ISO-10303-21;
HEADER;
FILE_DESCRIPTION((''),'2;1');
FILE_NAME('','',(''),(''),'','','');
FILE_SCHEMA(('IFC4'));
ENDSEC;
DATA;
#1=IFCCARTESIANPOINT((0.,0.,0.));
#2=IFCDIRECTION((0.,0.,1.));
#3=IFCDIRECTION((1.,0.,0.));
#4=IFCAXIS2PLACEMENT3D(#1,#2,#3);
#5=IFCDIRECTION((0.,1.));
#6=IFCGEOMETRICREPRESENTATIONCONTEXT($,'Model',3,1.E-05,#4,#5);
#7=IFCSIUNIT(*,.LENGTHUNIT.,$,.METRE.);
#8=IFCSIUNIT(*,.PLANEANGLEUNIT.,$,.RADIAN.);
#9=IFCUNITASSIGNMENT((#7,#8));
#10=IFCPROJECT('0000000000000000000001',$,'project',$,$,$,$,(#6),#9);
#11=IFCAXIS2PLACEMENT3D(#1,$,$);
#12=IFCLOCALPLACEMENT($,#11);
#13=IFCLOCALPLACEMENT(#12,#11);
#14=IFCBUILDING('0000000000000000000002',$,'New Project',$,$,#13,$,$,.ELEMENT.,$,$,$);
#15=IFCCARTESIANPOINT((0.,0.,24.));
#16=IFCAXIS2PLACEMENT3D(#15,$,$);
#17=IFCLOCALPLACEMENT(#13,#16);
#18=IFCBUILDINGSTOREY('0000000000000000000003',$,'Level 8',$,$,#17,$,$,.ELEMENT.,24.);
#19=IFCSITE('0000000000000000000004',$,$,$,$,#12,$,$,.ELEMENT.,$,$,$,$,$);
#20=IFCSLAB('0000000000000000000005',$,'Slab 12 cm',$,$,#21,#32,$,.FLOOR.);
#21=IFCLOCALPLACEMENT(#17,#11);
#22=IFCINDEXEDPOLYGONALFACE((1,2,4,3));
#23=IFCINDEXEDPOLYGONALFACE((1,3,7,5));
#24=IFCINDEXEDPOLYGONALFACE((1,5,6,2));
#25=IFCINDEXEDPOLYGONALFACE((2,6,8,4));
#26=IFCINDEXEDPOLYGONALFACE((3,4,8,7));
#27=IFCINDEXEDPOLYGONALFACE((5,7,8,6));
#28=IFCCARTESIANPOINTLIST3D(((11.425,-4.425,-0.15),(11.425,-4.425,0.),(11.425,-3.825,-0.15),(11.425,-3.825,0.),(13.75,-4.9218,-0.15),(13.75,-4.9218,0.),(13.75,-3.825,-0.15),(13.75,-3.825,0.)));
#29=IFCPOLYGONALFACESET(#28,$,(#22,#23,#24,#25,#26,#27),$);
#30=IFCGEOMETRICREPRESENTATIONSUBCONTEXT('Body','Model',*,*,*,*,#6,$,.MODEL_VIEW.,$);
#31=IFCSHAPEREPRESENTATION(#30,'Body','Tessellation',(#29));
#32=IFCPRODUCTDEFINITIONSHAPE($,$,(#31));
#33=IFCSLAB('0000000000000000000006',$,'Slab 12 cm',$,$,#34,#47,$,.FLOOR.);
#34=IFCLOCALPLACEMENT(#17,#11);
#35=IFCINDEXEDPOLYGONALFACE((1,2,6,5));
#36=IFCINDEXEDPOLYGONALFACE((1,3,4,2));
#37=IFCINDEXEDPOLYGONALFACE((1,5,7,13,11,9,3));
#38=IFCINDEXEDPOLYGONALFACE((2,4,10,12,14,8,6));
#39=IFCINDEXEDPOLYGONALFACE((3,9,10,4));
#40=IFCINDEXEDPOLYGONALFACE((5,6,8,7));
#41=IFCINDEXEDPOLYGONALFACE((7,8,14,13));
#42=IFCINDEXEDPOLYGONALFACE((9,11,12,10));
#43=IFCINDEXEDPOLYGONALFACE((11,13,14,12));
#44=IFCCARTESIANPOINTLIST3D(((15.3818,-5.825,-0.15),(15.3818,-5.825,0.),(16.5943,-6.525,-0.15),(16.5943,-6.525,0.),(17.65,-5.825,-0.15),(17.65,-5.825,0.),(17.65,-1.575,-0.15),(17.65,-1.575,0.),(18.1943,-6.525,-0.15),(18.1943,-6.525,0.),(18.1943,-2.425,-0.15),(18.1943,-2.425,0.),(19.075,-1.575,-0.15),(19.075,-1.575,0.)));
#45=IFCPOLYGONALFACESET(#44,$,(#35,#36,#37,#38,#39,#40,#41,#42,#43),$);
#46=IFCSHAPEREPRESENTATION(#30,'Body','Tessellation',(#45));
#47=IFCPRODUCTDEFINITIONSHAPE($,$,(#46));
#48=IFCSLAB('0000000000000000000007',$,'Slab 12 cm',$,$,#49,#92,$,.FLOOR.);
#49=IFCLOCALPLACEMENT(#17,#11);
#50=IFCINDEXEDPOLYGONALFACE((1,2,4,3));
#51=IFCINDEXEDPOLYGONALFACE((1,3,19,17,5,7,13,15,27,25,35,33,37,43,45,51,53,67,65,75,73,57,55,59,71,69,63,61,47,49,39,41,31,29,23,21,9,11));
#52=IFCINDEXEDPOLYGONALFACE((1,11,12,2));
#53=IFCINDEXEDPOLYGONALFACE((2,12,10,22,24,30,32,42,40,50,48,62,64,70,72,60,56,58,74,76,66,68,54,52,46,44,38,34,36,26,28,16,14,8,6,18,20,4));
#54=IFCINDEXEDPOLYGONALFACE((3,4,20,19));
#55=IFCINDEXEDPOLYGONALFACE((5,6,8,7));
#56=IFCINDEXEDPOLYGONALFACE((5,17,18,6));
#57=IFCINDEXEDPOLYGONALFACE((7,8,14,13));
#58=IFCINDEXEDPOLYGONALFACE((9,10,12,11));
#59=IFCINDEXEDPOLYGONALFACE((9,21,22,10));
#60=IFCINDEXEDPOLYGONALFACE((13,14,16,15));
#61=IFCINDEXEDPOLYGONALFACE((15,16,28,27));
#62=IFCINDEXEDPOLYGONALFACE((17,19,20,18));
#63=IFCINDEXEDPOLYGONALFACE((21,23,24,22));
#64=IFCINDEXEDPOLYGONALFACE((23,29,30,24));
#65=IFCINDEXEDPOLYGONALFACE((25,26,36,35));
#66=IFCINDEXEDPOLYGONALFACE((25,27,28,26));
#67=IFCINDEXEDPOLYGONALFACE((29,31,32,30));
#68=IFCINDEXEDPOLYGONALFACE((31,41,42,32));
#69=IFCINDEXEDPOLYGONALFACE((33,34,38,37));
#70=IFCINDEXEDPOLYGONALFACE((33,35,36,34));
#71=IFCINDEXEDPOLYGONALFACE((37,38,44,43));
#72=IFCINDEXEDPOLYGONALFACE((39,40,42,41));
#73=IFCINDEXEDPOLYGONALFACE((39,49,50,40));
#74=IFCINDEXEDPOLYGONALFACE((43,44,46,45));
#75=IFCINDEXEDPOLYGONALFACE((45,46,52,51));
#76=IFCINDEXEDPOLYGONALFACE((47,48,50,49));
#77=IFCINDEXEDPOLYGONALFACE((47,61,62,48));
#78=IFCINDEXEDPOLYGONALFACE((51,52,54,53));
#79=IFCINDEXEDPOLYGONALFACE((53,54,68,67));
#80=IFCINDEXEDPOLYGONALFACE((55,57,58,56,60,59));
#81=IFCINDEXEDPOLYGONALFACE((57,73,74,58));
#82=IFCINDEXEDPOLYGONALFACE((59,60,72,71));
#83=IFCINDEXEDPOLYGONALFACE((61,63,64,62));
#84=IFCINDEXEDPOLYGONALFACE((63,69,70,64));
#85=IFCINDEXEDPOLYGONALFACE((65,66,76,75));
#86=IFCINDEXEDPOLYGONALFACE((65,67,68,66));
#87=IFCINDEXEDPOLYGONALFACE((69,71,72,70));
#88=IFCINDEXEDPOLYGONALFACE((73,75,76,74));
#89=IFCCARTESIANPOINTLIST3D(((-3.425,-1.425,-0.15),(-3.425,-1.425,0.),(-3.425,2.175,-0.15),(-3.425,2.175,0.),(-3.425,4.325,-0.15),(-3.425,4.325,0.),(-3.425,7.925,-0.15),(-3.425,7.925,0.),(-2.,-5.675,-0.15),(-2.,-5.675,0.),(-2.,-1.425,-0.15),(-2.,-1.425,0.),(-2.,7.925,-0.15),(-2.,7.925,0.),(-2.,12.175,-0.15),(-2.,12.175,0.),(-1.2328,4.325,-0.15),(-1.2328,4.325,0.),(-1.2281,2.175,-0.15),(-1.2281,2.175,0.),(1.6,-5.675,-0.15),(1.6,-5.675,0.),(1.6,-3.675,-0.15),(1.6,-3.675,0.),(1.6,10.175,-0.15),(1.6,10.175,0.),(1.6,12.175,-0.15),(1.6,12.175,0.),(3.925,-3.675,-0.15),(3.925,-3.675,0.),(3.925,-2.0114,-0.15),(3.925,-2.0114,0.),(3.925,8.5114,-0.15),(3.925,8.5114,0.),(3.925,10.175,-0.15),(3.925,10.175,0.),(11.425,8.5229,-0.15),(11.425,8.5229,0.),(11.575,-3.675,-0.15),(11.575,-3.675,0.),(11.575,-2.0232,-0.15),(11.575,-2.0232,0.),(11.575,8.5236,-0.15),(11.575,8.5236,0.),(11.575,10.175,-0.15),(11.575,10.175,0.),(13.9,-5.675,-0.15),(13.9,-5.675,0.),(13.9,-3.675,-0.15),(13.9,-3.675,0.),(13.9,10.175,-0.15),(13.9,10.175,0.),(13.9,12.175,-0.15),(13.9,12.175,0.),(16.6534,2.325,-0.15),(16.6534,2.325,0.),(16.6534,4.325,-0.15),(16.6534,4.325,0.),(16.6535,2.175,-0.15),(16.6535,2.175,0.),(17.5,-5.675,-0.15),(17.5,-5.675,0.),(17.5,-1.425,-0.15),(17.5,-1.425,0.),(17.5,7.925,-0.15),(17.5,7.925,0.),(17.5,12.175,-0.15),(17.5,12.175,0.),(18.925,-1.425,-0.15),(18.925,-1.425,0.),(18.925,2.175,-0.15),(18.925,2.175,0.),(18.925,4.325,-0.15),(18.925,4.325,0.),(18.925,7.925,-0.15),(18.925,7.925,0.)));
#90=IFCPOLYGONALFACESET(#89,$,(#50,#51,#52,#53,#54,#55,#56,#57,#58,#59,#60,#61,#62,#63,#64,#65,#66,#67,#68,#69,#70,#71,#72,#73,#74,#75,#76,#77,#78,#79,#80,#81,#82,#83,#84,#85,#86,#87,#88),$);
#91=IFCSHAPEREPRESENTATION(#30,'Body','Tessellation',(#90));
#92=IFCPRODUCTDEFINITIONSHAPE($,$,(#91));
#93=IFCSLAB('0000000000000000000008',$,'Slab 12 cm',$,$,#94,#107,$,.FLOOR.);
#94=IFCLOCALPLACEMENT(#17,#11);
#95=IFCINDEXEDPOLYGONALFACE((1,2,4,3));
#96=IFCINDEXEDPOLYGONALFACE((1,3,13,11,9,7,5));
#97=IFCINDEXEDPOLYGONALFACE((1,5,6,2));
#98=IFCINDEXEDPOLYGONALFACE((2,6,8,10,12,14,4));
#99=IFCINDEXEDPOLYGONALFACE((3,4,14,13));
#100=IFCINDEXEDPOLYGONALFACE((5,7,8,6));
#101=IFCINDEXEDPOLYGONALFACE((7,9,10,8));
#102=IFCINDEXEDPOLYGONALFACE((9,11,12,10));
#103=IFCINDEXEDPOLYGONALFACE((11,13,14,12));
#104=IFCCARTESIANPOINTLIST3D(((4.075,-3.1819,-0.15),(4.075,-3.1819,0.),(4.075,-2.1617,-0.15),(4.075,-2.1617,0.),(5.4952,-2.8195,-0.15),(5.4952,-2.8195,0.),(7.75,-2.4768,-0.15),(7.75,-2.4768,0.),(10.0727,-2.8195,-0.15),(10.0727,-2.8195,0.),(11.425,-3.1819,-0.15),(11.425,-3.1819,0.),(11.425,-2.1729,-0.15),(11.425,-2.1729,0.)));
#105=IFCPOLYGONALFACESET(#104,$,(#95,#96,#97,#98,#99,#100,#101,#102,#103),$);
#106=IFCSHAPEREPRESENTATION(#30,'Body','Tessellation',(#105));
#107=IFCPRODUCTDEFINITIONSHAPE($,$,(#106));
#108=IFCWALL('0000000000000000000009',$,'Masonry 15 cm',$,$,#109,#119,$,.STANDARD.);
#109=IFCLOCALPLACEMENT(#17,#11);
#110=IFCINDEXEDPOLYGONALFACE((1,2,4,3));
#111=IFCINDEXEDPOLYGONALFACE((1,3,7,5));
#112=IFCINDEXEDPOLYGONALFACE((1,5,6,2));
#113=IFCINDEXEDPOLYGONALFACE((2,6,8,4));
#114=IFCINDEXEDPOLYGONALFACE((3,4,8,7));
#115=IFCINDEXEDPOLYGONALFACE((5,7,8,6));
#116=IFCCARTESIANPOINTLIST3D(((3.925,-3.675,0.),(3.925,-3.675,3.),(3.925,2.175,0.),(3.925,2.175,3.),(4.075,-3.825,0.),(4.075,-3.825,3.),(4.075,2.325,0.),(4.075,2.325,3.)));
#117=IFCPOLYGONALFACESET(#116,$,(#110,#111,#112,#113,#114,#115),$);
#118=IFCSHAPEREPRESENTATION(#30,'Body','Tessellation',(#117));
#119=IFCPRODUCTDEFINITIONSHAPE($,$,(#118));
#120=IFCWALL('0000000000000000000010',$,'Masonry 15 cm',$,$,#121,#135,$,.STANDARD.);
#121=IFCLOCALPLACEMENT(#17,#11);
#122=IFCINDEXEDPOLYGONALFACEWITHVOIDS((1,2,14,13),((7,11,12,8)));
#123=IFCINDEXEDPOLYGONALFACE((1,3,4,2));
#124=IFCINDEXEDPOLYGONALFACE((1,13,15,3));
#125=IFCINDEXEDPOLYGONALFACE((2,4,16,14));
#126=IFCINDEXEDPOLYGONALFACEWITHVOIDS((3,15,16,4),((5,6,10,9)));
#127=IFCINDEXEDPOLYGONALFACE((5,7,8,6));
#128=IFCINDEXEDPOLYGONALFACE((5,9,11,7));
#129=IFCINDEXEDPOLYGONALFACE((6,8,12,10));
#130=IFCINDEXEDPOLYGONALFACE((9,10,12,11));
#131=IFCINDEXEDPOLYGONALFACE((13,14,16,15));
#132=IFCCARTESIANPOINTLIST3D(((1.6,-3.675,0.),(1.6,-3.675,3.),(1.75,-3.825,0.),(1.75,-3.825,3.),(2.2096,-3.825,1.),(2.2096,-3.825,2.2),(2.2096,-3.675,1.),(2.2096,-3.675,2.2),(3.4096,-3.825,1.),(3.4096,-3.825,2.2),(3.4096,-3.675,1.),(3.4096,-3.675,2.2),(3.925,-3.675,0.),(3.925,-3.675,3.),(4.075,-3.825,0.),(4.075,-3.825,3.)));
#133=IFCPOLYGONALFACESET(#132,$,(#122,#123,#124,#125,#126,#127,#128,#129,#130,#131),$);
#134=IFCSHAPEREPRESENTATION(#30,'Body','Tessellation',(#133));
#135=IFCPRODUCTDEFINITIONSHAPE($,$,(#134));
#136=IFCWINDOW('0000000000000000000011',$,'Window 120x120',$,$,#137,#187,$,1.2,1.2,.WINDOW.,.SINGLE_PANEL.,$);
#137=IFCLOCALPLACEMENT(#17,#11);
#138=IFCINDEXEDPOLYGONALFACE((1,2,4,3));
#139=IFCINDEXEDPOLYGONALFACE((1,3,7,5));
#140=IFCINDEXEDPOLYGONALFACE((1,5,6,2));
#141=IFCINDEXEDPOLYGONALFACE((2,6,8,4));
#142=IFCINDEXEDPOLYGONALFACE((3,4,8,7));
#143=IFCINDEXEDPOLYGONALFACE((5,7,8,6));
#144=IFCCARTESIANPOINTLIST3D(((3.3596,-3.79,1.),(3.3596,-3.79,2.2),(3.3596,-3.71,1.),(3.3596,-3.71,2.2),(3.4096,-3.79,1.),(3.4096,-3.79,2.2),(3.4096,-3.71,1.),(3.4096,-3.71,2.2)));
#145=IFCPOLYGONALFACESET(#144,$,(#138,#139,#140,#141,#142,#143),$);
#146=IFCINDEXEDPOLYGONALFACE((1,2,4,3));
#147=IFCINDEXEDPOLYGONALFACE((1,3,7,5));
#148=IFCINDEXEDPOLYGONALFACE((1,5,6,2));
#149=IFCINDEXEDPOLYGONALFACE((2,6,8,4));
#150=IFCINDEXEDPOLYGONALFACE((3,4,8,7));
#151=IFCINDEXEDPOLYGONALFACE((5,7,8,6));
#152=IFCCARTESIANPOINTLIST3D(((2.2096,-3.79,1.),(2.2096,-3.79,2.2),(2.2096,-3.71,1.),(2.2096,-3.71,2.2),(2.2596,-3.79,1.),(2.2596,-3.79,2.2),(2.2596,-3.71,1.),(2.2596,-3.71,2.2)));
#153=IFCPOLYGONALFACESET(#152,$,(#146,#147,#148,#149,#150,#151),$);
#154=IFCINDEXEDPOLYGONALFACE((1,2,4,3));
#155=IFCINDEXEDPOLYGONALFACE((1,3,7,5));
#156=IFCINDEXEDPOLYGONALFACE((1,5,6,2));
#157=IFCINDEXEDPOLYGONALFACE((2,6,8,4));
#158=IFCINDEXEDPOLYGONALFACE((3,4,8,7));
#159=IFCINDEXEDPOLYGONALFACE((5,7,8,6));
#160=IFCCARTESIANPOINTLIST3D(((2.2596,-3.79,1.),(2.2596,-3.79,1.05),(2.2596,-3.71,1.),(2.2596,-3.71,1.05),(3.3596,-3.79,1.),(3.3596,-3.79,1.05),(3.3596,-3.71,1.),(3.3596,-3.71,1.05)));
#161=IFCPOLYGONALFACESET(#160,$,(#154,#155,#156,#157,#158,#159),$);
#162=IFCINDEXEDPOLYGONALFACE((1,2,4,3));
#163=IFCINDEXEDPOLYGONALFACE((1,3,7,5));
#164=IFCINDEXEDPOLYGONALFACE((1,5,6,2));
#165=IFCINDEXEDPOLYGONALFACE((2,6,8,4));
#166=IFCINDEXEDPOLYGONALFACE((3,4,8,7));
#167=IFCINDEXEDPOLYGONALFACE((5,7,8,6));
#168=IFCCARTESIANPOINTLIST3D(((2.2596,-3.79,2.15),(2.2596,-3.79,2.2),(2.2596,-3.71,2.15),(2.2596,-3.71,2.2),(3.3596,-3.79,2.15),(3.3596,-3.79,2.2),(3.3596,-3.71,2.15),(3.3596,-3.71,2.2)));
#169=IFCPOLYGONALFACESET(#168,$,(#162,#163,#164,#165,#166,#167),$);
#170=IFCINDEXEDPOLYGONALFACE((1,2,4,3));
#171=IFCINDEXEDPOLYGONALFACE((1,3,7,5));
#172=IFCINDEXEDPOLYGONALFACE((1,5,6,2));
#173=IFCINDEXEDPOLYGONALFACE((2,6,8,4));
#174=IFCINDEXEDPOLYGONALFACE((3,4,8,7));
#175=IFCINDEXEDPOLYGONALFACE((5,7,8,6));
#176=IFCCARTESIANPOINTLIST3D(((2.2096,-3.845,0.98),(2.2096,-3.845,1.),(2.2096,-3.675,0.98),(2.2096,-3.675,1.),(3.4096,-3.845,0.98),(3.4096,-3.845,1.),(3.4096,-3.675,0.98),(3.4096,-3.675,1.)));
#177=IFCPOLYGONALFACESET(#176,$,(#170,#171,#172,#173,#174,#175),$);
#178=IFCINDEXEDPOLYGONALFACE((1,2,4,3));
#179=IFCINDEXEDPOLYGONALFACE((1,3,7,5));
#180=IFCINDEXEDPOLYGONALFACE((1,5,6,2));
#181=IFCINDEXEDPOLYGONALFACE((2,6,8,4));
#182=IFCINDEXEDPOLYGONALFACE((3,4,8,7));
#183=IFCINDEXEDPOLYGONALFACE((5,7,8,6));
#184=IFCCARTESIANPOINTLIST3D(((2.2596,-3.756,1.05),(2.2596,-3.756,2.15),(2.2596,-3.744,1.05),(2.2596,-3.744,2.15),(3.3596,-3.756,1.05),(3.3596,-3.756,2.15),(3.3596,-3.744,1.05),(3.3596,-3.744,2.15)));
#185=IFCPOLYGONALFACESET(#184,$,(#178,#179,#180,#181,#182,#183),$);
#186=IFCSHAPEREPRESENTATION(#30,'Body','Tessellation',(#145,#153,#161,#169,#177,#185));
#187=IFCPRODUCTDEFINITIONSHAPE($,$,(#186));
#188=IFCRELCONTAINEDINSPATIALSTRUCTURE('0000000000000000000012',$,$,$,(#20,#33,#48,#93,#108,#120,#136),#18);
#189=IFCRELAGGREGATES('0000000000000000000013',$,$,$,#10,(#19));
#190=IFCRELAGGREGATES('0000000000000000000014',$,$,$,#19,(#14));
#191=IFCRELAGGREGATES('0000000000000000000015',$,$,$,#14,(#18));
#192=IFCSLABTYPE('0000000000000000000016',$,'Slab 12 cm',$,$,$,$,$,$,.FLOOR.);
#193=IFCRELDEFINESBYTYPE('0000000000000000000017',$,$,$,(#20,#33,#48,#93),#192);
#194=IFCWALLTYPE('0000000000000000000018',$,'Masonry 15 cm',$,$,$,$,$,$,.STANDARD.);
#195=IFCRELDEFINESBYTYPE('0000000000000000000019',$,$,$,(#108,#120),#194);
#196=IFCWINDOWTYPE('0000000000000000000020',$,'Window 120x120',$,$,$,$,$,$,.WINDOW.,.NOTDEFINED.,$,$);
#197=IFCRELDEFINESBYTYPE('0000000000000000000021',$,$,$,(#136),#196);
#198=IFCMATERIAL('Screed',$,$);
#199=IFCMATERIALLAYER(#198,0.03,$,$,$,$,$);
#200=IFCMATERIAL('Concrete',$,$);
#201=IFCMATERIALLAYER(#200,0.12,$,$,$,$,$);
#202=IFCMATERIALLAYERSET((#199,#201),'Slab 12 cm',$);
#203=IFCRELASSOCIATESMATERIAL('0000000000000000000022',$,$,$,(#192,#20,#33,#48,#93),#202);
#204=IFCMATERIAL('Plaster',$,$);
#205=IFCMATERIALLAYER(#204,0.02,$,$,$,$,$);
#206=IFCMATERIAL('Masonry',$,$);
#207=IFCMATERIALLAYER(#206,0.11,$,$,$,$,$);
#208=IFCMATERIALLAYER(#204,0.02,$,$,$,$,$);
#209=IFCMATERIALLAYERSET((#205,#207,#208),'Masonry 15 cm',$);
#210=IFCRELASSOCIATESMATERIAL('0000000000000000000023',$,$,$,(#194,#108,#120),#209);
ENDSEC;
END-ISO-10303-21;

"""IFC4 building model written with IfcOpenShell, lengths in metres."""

from ifc_helpers import new_model, si_unit, direction, frame, frame_2d, origin, origin_with_axes, place, context, subcontext, project, spatial, polyline, rectangle, outline, extrude, material, layer, layer_set, layer_usage, type_object, element, fill, save


model = new_model("IFC4")

# Units and contexts
model_context = context("Model", 3, precision=1e-05, world=origin_with_axes(), true_north=direction((0.0, 1.0)))
body_context = subcontext(model_context, "Body", "Model", "MODEL_VIEW")
ifc_project = project(units=[si_unit("LENGTHUNIT", "METRE"), si_unit("PLANEANGLEUNIT", "RADIAN")], contexts=[model_context])

# Site, building, storey
site_placement = place(None, origin())
site = spatial("IfcSite", under=ifc_project, at=site_placement, CompositionType="ELEMENT")
building_placement = place(site_placement, origin())
building = spatial("IfcBuilding", under=site, at=building_placement, Name="New Project", CompositionType="ELEMENT")
storey_placement = place(building_placement, frame((0.0, 0.0, 24.0)))
storey = spatial("IfcBuildingStorey", under=building, at=storey_placement, Name="Level 8", CompositionType="ELEMENT", Elevation=24.0)

# Slabs
ifc_material_1 = material(Name="Screed")
ifc_layer_1 = layer(ifc_material_1, 0.03)
ifc_material_2 = material(Name="Concrete")
ifc_layer_2 = layer(ifc_material_2, 0.12)
ifc_layer_set_1 = layer_set([ifc_layer_1, ifc_layer_2], Name="Slab 12 cm")
ifc_layer_usage_1 = layer_usage(ifc_layer_set_1, "AXIS3", "NEGATIVE", 0.15)
slab_type = type_object("IfcSlabType", Name="Slab 12 cm", PredefinedType="FLOOR", material=ifc_layer_set_1)
slab_1_placement = place(storey_placement, frame((0.0, 0.0, -0.15)))
element("IfcSlab", 1, at=slab_1_placement, inside=storey, type_object=slab_type, material=ifc_layer_usage_1, Name="Slab 12 cm", PredefinedType="FLOOR", context=body_context, shape_type="SweptSolid", body=[
    extrude(outline(polyline([(11.425, -3.825), (11.425, -4.425), (13.75, -4.9218), (13.75, -3.825), (11.425, -3.825)])), origin(), (0.0, 0.0, 1.0), 0.15),
])
slab_2_placement = place(storey_placement, frame((0.0, 0.0, -0.15)))
element("IfcSlab", 2, at=slab_2_placement, inside=storey, type_object=slab_type, material=ifc_layer_usage_1, Name="Slab 12 cm", PredefinedType="FLOOR", context=body_context, shape_type="SweptSolid", body=[
    extrude(outline(polyline([(15.3818, -5.825), (16.5943, -6.525), (18.1943, -6.525), (18.1943, -2.425), (19.075, -1.575), (17.65, -1.575), (17.65, -5.825), (15.3818, -5.825)])), origin(), (0.0, 0.0, 1.0), 0.15),
])
slab_3_placement = place(storey_placement, frame((0.0, 0.0, -0.15)))
element("IfcSlab", 3, at=slab_3_placement, inside=storey, type_object=slab_type, material=ifc_layer_usage_1, Name="Slab 12 cm", PredefinedType="FLOOR", context=body_context, shape_type="SweptSolid", body=[
    extrude(outline(polyline([(-2.0, 7.925), (-3.425, 7.925), (-3.425, 4.325), (-1.2328, 4.325), (-1.2281, 2.175), (-3.425, 2.175), (-3.425, -1.425), (-2.0, -1.425), (-2.0, -5.675), (1.6, -5.675), (1.6, -3.675), (3.925, -3.675), (3.925, -2.0114), (11.575, -2.0232), (11.575, -3.675), (13.9, -3.675), (13.9, -5.675), (17.5, -5.675), (17.5, -1.425), (18.925, -1.425), (18.925, 2.175), (16.6535, 2.175), (16.6534, 2.325), (16.6534, 4.325), (18.925, 4.325), (18.925, 7.925), (17.5, 7.925), (17.5, 12.175), (13.9, 12.175), (13.9, 10.175), (11.575, 10.175), (11.575, 8.5236), (11.425, 8.5229), (3.925, 8.5114), (3.925, 10.175), (1.6, 10.175), (1.6, 12.175), (-2.0, 12.175), (-2.0, 7.925)])), origin(), (0.0, 0.0, 1.0), 0.15),
])
slab_4_placement = place(storey_placement, frame((0.0, 0.0, -0.15)))
element("IfcSlab", 4, at=slab_4_placement, inside=storey, type_object=slab_type, material=ifc_layer_usage_1, Name="Slab 12 cm", PredefinedType="FLOOR", context=body_context, shape_type="SweptSolid", body=[
    extrude(outline(polyline([(4.075, -3.1819), (5.4952, -2.8195), (7.75, -2.4768), (10.0727, -2.8195), (11.425, -3.1819), (11.425, -2.1729), (4.075, -2.1617), (4.075, -3.1819)])), origin(), (0.0, 0.0, 1.0), 0.15),
])

# Wall
ifc_material_3 = material(Name="Plaster")
ifc_layer_3 = layer(ifc_material_3, 0.02)
ifc_material_4 = material(Name="Masonry")
ifc_layer_4 = layer(ifc_material_4, 0.11)
ifc_layer_5 = layer(ifc_material_3, 0.02)
ifc_layer_set_2 = layer_set([ifc_layer_3, ifc_layer_4, ifc_layer_5], Name="Masonry 15 cm")
ifc_layer_usage_2 = layer_usage(ifc_layer_set_2, "AXIS2", "NEGATIVE", 0.075)
wall_type_1 = type_object("IfcWallType", Name="Masonry 15 cm", PredefinedType="STANDARD", material=ifc_layer_set_2)
wall_1_placement = place(storey_placement, frame((4.0, 2.25, 0.0), z_axis=(0.0, 0.0, 1.0), x_axis=(0.0, -1.0, 0.0)))
element("IfcWall", 5, at=wall_1_placement, inside=storey, type_object=wall_type_1, material=ifc_layer_usage_2, Name="Masonry 15 cm", PredefinedType="STANDARD", context=body_context, shape_type="SweptSolid", body=[
    extrude(outline(polyline([(0.075, -0.075), (5.925, -0.075), (6.075, 0.075), (-0.075, 0.075), (0.075, -0.075)])), origin(), (0.0, 0.0, 1.0), 3.0),
])

# Wall, opening, window
wall_2_placement = place(storey_placement, frame((4.0, -3.75, 0.0), z_axis=(0.0, 0.0, 1.0), x_axis=(-1.0, 0.0, 0.0)))
wall_2 = element("IfcWall", 6, at=wall_2_placement, inside=storey, type_object=wall_type_1, material=ifc_layer_usage_2, Name="Masonry 15 cm", PredefinedType="STANDARD", context=body_context, shape_type="SweptSolid", body=[
    extrude(outline(polyline([(0.075, -0.075), (2.4, -0.075), (2.25, 0.075), (-0.075, 0.075), (0.075, -0.075)])), origin(), (0.0, 0.0, 1.0), 3.0),
])
opening_1_placement = place(wall_2_placement, frame((0.5904, 0.0, 1.0)))
opening_1 = element("IfcOpeningElement", 7, at=opening_1_placement, cuts=wall_2, PredefinedType="OPENING", context=body_context, shape_type="SweptSolid", body=[
    extrude(rectangle(XDim=1.2, YDim=0.25, at=frame_2d((0.6, 0.0))), origin(), (0.0, 0.0, 1.0), 1.2),
])
window_type = type_object("IfcWindowType", Name="Window 120x120", PartitioningType="NOTDEFINED", PredefinedType="WINDOW")
window_1_placement = place(opening_1_placement, origin())
window_1 = element("IfcWindow", 8, at=window_1_placement, inside=storey, type_object=window_type, Name="Window 120x120", OverallHeight=1.2, OverallWidth=1.2, PartitioningType="SINGLE_PANEL", PredefinedType="WINDOW", context=body_context, shape_type="SweptSolid", body=[
    extrude(outline(polyline([(0.0, -0.04), (0.05, -0.04), (0.05, 0.04), (0.0, 0.04), (0.0, -0.04)])), origin(), (0.0, 0.0, 1.0), 1.2),
    extrude(outline(polyline([(1.15, -0.04), (1.2, -0.04), (1.2, 0.04), (1.15, 0.04), (1.15, -0.04)])), origin(), (0.0, 0.0, 1.0), 1.2),
    extrude(outline(polyline([(0.05, -0.04), (1.15, -0.04), (1.15, 0.04), (0.05, 0.04), (0.05, -0.04)])), origin(), (0.0, 0.0, 1.0), 0.05),
    extrude(outline(polyline([(0.05, -0.04), (1.15, -0.04), (1.15, 0.04), (0.05, 0.04), (0.05, -0.04)])), frame((0.0, 0.0, 1.15)), (0.0, 0.0, 1.0), 0.05),
    extrude(outline(polyline([(0.0, -0.075), (1.2, -0.075), (1.2, 0.095), (0.0, 0.095), (0.0, -0.075)])), frame((0.0, 0.0, -0.02)), (0.0, 0.0, 1.0), 0.02),
    extrude(outline(polyline([(0.05, -0.006), (1.15, -0.006), (1.15, 0.006), (0.05, 0.006), (0.05, -0.006)])), frame((0.0, 0.0, 0.05)), (0.0, 0.0, 1.0), 1.1),
])
fill(opening_1, window_1)

save(model, "model.ifc")
